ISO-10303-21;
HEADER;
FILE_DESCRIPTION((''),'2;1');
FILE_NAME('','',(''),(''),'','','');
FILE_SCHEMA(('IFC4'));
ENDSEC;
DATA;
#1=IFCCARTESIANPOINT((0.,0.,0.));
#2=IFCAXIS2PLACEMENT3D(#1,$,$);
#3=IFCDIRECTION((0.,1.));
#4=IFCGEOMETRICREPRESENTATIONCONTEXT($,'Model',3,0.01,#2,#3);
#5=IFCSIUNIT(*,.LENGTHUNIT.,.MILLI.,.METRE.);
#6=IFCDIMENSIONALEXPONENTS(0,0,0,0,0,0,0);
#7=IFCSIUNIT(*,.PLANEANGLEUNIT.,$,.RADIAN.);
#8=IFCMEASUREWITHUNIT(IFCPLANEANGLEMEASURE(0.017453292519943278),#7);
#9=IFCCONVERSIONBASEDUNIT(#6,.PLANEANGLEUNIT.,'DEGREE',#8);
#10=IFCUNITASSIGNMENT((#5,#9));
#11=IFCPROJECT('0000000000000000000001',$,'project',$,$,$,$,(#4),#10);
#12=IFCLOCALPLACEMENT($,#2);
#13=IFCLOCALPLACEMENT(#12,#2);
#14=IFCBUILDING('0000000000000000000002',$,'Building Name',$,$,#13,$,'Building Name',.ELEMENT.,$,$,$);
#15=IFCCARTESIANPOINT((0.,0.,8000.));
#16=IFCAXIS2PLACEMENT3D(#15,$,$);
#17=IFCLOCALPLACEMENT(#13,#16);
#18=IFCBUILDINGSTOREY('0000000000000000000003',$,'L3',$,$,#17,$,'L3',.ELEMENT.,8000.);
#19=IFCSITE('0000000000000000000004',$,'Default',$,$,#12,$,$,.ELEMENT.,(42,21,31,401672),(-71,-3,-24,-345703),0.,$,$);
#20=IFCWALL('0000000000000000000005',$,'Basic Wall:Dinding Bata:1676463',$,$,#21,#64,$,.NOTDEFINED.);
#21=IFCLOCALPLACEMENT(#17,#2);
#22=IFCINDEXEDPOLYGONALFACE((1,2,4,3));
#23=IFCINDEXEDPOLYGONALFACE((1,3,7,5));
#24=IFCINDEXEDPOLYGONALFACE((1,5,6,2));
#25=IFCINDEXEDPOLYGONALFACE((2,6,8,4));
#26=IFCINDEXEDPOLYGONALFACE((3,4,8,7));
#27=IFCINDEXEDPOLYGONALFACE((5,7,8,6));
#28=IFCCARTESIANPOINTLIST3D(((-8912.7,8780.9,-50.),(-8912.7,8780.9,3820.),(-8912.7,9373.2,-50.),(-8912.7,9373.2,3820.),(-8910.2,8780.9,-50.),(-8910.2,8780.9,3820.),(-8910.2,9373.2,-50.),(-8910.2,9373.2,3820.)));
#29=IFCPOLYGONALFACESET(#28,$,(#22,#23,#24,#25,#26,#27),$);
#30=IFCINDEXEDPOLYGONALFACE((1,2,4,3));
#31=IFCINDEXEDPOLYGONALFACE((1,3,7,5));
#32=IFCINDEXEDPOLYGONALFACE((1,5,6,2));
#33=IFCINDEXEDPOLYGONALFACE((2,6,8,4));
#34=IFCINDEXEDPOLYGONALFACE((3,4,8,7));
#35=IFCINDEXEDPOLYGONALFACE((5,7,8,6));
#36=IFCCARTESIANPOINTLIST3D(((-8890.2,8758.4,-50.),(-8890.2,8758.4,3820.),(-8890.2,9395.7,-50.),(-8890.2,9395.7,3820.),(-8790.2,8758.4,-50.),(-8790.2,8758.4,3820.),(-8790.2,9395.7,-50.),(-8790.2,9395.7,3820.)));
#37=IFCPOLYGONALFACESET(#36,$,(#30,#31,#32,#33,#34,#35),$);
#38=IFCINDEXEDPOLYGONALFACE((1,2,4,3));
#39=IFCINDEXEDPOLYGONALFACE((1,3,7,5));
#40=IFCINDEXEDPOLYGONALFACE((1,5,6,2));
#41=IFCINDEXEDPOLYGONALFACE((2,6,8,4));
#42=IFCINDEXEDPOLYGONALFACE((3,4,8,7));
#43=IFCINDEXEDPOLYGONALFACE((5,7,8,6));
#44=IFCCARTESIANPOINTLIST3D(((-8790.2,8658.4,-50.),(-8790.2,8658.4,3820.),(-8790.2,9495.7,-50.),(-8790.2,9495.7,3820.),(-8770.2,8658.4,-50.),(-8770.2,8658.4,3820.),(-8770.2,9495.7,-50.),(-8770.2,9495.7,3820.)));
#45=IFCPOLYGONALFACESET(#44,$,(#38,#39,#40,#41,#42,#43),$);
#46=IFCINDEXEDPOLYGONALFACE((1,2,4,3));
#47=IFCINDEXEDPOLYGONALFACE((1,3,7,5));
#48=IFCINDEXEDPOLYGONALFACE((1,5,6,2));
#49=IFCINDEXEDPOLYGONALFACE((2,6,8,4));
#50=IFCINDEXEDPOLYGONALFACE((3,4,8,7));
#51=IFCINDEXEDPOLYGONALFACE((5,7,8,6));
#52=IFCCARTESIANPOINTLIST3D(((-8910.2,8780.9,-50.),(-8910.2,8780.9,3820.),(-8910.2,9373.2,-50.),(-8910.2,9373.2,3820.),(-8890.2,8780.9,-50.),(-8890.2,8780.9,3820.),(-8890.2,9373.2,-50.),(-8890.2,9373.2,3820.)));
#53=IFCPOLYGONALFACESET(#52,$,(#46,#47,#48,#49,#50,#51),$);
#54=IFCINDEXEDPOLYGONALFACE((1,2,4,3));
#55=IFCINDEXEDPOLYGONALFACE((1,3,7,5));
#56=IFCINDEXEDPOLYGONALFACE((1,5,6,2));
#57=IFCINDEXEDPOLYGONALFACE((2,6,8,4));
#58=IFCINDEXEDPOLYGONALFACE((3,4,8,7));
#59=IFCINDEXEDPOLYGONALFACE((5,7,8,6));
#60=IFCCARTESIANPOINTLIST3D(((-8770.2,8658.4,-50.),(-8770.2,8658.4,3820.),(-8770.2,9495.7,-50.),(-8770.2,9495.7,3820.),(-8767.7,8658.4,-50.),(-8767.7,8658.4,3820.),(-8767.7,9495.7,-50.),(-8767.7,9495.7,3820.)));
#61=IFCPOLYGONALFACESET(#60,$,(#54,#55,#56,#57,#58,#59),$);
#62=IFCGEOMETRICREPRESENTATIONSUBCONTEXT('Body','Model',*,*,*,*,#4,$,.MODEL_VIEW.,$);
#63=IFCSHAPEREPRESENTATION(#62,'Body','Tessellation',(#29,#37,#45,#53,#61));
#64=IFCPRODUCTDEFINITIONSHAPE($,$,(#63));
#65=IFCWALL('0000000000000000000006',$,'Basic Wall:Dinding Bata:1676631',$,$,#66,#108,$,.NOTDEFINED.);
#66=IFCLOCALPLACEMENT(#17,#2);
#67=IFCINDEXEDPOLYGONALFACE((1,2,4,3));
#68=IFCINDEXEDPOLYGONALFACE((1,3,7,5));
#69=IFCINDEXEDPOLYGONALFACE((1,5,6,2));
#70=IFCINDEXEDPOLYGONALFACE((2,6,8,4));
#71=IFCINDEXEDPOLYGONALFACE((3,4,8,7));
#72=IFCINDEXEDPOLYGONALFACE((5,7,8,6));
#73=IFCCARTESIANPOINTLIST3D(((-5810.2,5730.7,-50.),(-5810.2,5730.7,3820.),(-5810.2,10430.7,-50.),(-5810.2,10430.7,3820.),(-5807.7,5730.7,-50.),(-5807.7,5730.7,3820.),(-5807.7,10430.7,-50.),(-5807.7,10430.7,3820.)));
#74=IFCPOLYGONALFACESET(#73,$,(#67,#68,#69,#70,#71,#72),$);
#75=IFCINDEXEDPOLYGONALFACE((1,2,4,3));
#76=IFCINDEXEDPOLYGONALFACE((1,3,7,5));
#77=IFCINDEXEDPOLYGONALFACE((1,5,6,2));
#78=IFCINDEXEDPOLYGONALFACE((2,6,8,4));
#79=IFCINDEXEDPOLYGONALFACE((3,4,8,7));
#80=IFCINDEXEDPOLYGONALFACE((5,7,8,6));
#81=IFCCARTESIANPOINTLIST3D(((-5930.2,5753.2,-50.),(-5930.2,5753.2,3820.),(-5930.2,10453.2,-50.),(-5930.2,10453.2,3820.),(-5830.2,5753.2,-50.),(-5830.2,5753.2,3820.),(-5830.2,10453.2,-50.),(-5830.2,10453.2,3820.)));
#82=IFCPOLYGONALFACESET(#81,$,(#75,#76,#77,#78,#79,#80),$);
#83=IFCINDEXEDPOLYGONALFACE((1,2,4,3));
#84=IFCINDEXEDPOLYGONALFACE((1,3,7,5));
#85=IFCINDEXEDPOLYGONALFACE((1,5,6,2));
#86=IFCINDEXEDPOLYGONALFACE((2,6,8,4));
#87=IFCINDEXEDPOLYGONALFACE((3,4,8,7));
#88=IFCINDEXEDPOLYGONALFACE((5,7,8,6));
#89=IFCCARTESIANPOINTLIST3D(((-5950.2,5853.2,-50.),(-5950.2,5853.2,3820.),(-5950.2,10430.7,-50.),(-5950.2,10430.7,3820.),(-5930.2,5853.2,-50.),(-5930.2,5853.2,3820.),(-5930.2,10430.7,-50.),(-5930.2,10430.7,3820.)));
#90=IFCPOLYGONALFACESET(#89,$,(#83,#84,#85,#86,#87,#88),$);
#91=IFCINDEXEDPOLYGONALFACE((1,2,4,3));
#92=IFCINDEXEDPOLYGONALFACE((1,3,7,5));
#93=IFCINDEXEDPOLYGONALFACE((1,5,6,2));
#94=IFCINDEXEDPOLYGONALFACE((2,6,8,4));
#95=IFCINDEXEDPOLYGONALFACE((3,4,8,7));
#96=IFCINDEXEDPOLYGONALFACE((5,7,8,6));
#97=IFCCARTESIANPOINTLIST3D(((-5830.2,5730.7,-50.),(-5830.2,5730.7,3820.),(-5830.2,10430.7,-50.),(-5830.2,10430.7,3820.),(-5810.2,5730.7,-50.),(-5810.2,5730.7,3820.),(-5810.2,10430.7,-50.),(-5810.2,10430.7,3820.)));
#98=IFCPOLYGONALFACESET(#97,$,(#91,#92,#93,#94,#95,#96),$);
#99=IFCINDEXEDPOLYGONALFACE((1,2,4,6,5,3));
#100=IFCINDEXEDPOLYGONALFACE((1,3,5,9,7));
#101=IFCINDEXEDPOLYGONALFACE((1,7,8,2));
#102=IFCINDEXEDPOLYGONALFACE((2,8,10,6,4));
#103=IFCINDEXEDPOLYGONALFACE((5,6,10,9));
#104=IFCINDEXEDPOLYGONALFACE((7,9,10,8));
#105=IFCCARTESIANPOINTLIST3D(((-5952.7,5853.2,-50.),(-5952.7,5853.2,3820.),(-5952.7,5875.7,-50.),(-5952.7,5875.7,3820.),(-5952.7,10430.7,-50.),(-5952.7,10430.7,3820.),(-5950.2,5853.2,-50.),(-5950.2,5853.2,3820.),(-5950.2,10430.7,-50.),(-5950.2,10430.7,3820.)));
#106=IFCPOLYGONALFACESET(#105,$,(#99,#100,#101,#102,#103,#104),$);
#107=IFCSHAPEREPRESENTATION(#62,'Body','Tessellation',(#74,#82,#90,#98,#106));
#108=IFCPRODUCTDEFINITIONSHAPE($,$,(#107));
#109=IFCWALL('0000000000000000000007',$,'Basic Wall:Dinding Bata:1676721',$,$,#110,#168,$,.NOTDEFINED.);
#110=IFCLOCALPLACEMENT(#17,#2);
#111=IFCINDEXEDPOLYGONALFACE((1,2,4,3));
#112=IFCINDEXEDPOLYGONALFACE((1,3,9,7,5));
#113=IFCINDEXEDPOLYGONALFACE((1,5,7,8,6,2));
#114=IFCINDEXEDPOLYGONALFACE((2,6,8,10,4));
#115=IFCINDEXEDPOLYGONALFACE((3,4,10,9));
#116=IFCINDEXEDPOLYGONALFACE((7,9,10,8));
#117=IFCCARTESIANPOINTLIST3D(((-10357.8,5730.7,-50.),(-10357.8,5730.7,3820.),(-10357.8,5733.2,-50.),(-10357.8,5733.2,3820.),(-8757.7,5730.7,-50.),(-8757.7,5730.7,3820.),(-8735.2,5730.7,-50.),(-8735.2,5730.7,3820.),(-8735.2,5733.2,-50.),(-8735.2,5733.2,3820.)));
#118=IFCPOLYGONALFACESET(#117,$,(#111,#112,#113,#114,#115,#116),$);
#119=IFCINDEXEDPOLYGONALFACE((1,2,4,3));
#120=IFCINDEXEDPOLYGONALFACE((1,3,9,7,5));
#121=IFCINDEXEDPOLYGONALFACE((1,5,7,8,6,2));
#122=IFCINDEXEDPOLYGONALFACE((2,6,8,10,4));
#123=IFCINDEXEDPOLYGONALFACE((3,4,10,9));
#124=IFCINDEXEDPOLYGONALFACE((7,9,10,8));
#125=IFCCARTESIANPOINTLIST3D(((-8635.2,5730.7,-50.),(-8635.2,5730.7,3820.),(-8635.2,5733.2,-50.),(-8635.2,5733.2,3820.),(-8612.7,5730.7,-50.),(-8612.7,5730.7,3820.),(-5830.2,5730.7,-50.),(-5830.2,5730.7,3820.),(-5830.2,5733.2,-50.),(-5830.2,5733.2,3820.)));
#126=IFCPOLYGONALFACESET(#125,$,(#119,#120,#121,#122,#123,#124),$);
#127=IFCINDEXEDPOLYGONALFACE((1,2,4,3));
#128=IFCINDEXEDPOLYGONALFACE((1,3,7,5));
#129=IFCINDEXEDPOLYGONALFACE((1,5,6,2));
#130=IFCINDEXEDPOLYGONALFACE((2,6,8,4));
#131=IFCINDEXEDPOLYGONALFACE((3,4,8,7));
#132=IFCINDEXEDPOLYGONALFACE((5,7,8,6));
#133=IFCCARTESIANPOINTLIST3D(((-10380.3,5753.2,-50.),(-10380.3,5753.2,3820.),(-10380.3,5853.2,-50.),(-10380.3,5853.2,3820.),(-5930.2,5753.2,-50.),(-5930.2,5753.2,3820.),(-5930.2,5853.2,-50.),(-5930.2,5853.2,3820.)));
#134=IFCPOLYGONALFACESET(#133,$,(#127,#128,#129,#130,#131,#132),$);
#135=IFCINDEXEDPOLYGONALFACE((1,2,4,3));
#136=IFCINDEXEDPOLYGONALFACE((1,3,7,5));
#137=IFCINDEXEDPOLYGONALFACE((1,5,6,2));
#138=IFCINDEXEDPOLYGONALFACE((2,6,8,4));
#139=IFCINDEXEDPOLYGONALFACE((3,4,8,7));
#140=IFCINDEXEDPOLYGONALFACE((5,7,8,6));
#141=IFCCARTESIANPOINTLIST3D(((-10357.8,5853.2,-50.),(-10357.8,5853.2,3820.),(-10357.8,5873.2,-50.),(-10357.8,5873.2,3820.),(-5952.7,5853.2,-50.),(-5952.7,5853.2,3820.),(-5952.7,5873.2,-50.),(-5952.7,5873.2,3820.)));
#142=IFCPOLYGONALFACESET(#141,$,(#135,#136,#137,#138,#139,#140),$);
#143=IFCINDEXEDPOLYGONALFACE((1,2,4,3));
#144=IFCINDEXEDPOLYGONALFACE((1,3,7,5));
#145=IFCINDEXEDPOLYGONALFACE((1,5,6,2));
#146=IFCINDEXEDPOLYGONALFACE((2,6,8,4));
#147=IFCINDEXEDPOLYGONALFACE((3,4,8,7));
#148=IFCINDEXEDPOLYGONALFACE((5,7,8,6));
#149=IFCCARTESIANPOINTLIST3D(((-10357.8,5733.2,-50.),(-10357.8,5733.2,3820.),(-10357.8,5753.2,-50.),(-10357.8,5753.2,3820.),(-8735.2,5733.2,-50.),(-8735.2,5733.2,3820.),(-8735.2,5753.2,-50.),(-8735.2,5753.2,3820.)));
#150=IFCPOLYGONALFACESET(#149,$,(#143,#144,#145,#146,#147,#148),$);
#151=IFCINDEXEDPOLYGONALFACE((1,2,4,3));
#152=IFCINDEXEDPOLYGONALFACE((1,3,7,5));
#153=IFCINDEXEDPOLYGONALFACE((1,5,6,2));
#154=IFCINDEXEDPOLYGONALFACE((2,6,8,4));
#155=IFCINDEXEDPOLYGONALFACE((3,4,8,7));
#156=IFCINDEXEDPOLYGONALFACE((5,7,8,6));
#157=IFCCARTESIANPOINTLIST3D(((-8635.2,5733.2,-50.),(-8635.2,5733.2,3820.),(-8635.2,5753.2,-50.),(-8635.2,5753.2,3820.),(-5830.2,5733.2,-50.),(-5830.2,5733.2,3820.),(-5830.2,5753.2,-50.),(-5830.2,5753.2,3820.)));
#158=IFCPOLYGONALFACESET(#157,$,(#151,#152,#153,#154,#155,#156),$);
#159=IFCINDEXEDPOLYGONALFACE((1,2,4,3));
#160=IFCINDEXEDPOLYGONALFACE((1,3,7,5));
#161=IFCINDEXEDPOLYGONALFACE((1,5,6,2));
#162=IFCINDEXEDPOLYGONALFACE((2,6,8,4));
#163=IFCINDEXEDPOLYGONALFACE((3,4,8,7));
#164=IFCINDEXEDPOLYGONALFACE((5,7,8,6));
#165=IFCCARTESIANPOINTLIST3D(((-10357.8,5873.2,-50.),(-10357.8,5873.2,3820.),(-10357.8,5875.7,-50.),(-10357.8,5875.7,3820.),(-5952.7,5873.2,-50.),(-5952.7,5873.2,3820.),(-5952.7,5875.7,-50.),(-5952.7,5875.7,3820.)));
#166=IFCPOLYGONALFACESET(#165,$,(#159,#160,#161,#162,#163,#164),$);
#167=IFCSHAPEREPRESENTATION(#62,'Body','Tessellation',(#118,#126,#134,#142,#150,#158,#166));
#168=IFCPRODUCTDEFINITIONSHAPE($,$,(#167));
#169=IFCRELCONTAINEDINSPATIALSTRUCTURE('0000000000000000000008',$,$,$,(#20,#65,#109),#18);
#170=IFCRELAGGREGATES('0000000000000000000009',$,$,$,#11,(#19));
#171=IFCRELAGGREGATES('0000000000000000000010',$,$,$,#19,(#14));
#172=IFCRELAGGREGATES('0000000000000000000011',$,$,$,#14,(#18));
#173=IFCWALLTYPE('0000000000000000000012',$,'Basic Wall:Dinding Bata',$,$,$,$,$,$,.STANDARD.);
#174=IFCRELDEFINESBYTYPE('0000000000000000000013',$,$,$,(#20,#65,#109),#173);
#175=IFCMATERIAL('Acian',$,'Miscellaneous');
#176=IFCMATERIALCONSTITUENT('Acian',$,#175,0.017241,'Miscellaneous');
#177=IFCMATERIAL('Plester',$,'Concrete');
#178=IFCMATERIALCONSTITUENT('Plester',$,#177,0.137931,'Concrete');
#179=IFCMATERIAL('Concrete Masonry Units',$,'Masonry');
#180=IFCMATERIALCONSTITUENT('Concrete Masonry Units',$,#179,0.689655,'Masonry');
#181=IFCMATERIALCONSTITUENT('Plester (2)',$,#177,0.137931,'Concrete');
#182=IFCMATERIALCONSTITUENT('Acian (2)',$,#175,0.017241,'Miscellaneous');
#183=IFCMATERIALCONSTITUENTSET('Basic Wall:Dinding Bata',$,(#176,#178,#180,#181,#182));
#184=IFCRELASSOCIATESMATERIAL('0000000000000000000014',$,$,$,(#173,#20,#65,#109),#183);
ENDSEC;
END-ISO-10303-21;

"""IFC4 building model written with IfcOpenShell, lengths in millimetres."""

from ifc_helpers import new_model, entity, si_unit, converted_unit, direction, frame, origin, place, context, subcontext, project, spatial, indexed_curve, outline, extrude, material, constituent, constituent_set, type_object, element, save


model = new_model("IFC4")

# Units and contexts
model_context = context("Model", 3, precision=0.01, world=origin(), true_north=direction((0.0, 1.0)))
body_context = subcontext(model_context, "Body", "Model", "MODEL_VIEW")
ifc_project = project(units=[si_unit("LENGTHUNIT", "METRE", prefix="MILLI"), converted_unit("PLANEANGLEUNIT", "DEGREE", entity("IfcPlaneAngleMeasure", 0.017453292519943278), si_unit("PLANEANGLEUNIT", "RADIAN"), dimensions=[0, 0, 0, 0, 0, 0, 0])], contexts=[model_context])

# Site, building, storey
site_placement = place(None, origin())
site = spatial("IfcSite", under=ifc_project, at=site_placement, Name="Default", CompositionType="ELEMENT", RefLatitude=(42, 21, 31, 401672), RefLongitude=(-71, -3, -24, -345703), RefElevation=0.0)
building_placement = place(site_placement, origin())
building = spatial("IfcBuilding", under=site, at=building_placement, Name="Building Name", LongName="Building Name", CompositionType="ELEMENT")
storey_placement = place(building_placement, frame((0.0, 0.0, 8000.0)))
storey = spatial("IfcBuildingStorey", under=building, at=storey_placement, Name="L3", LongName="L3", CompositionType="ELEMENT", Elevation=8000.0)

# Walls
ifc_material_1 = material(Name="Acian", Category="Miscellaneous")
ifc_constituent_1 = constituent(ifc_material_1, Name="Acian", Category="Miscellaneous", fraction=0.017241)
ifc_material_2 = material(Name="Plester", Category="Concrete")
ifc_constituent_2 = constituent(ifc_material_2, Name="Plester", Category="Concrete", fraction=0.137931)
ifc_material_3 = material(Name="Concrete Masonry Units", Category="Masonry")
ifc_constituent_3 = constituent(ifc_material_3, Name="Concrete Masonry Units", Category="Masonry", fraction=0.689655)
ifc_constituent_4 = constituent(ifc_material_2, Name="Plester (2)", Category="Concrete", fraction=0.137931)
ifc_constituent_5 = constituent(ifc_material_1, Name="Acian (2)", Category="Miscellaneous", fraction=0.017241)
ifc_constituent_set = constituent_set(constituents=[ifc_constituent_1, ifc_constituent_2, ifc_constituent_3, ifc_constituent_4, ifc_constituent_5], Name="Basic Wall:Dinding Bata")
wall_type = type_object("IfcWallType", Name="Basic Wall:Dinding Bata", PredefinedType="STANDARD", material=ifc_constituent_set)
wall_1_placement = place(storey_placement, frame((-8840.2, 8780.9, -50.0), z_axis=(0.0, 0.0, 1.0), x_axis=(0.0, 1.0, 0.0)))
element("IfcWall", 1, at=wall_1_placement, inside=storey, type_object=wall_type, material=ifc_constituent_set, Name="Basic Wall:Dinding Bata:1676463", PredefinedType="NOTDEFINED", context=body_context, shape_type="SweptSolid", body=[
    extrude(outline(indexed_curve([(-1.2, -296.2), (1.2, -296.2), (1.3, 296.2), (-1.2, 296.2), (-1.2, -296.2)], self_intersect=False)), frame((296.2, 71.3, 0.0), z_axis=(0.0, 0.0, 1.0), x_axis=(0.0, -1.0, 0.0)), (0.0, 0.0, 1.0), 3870.0),
    extrude(outline(indexed_curve([(-318.7, -50.0), (318.7, -50.0), (318.7, 50.0), (-318.7, 50.0), (-318.7, -50.0)], self_intersect=False)), frame((296.2, 0.0, 0.0)), (0.0, 0.0, 1.0), 3870.0),
    extrude(outline(indexed_curve([(-418.7, -10.0), (418.7, -10.0), (418.7, 10.0), (-418.7, 10.0), (-418.7, -10.0)], self_intersect=False)), frame((296.2, -60.0, 0.0)), (0.0, 0.0, 1.0), 3870.0),
    extrude(outline(indexed_curve([(-296.2, -10.0), (296.2, -10.0), (296.2, 10.0), (-296.2, 10.0), (-296.2, -10.0)], self_intersect=False)), frame((296.2, 60.0, 0.0)), (0.0, 0.0, 1.0), 3870.0),
    extrude(outline(indexed_curve([(-1.3, -418.7), (1.2, -418.7), (1.2, 418.7), (-1.2, 418.7), (-1.3, -418.7)], self_intersect=False)), frame((296.2, -71.2, 0.0), z_axis=(0.0, 0.0, 1.0), x_axis=(0.0, 1.0, 0.0)), (0.0, 0.0, 1.0), 3870.0),
])
wall_2_placement = place(storey_placement, frame((-5880.2, 10430.7, -50.0), z_axis=(0.0, 0.0, 1.0), x_axis=(0.0, -1.0, 0.0)))
element("IfcWall", 2, at=wall_2_placement, inside=storey, type_object=wall_type, material=ifc_constituent_set, Name="Basic Wall:Dinding Bata:1676631", PredefinedType="NOTDEFINED", context=body_context, shape_type="SweptSolid", body=[
    extrude(outline(indexed_curve([(-1.3, -2350.0), (1.2, -2350.0), (1.3, 2350.0), (-1.2, 2350.0), (-1.3, -2350.0)], self_intersect=False)), frame((2350.0, 71.3, 0.0), z_axis=(0.0, 0.0, 1.0), x_axis=(0.0, -1.0, 0.0)), (0.0, 0.0, 1.0), 3870.0),
    extrude(outline(indexed_curve([(-2350.0, -50.0), (2350.0, -50.0), (2350.0, 50.0), (-2350.0, 50.0), (-2350.0, -50.0)], self_intersect=False)), frame((2327.5, 0.0, 0.0)), (0.0, 0.0, 1.0), 3870.0),
    extrude(outline(indexed_curve([(-2288.8, -10.0), (2288.8, -10.0), (2288.8, 10.0), (-2288.8, 10.0), (-2288.8, -10.0)], self_intersect=False)), frame((2288.8, -60.0, 0.0)), (0.0, 0.0, 1.0), 3870.0),
    extrude(outline(indexed_curve([(-2350.0, -10.0), (2350.0, -10.0), (2350.0, 10.0), (-2350.0, 10.0), (-2350.0, -10.0)], self_intersect=False)), frame((2350.0, 60.0, 0.0)), (0.0, 0.0, 1.0), 3870.0),
    extrude(outline(indexed_curve([(1813.0, -1.0), (1835.5, -1.0), (1835.5, 1.5), (-2742.0, 1.5), (-2742.0, -1.0), (1813.0, -1.0)], self_intersect=False)), frame((2742.0, -71.5, 0.0)), (0.0, 0.0, 1.0), 3870.0),
])
wall_3_placement = place(storey_placement, frame((-5952.7, 5803.2, -50.0), z_axis=(0.0, 0.0, 1.0), x_axis=(-1.0, 0.0, 0.0)))
element("IfcWall", 3, at=wall_3_placement, inside=storey, type_object=wall_type, material=ifc_constituent_set, Name="Basic Wall:Dinding Bata:1676721", PredefinedType="NOTDEFINED", context=body_context, shape_type="SweptSolid", body=[
    extrude(outline(indexed_curve([(631.0, -1.0), (653.5, -1.0), (653.5, 1.5), (-969.0, 1.5), (-969.0, -1.0), (631.0, -1.0)], self_intersect=False)), frame((3436.0, 71.5, 0.0), z_axis=(0.0, 0.0, 1.0), x_axis=(-1.0, 0.0, 0.0)), (0.0, 0.0, 1.0), 3870.0),
    extrude(outline(indexed_curve([(-1.0, -1678.5), (1.5, -1678.5), (1.5, 1126.5), (-1.0, 1126.5), (-1.0, 1104.0), (-1.0, -1678.5)], self_intersect=False)), frame((1556.0, 71.5, 0.0), z_axis=(0.0, 0.0, 1.0), x_axis=(0.0, -1.0, 0.0)), (0.0, 0.0, 1.0), 3870.0),
    extrude(outline(indexed_curve([(-2225.0, -50.0), (2225.0, -50.0), (2225.0, 50.0), (-2225.0, 50.0), (-2225.0, -50.0)], self_intersect=False)), frame((2202.5, 0.0, 0.0)), (0.0, 0.0, 1.0), 3870.0),
    extrude(outline(indexed_curve([(-2202.5, -10.0), (2202.5, -10.0), (2202.5, 10.0), (-2202.5, 10.0), (-2202.5, -10.0)], self_intersect=False)), frame((2202.5, -60.0, 0.0)), (0.0, 0.0, 1.0), 3870.0),
    extrude(outline(indexed_curve([(-811.3, -10.0), (811.3, -10.0), (811.3, 10.0), (-811.3, 10.0), (-811.3, -10.0)], self_intersect=False)), frame((3593.8, 60.0, 0.0), z_axis=(0.0, 0.0, 1.0), x_axis=(-1.0, 0.0, 0.0)), (0.0, 0.0, 1.0), 3870.0),
    extrude(outline(indexed_curve([(-1402.5, -10.0), (1402.5, -10.0), (1402.5, 10.0), (-1402.5, 10.0), (-1402.5, -10.0)], self_intersect=False)), frame((1280.0, 60.0, 0.0)), (0.0, 0.0, 1.0), 3870.0),
    extrude(outline(indexed_curve([(-1.3, -2202.5), (1.2, -2202.5), (1.3, 2202.5), (-1.2, 2202.5), (-1.3, -2202.5)], self_intersect=False)), frame((2202.5, -71.3, 0.0), z_axis=(0.0, 0.0, 1.0), x_axis=(0.0, 1.0, 0.0)), (0.0, 0.0, 1.0), 3870.0),
])

save(model, "model.ifc")
